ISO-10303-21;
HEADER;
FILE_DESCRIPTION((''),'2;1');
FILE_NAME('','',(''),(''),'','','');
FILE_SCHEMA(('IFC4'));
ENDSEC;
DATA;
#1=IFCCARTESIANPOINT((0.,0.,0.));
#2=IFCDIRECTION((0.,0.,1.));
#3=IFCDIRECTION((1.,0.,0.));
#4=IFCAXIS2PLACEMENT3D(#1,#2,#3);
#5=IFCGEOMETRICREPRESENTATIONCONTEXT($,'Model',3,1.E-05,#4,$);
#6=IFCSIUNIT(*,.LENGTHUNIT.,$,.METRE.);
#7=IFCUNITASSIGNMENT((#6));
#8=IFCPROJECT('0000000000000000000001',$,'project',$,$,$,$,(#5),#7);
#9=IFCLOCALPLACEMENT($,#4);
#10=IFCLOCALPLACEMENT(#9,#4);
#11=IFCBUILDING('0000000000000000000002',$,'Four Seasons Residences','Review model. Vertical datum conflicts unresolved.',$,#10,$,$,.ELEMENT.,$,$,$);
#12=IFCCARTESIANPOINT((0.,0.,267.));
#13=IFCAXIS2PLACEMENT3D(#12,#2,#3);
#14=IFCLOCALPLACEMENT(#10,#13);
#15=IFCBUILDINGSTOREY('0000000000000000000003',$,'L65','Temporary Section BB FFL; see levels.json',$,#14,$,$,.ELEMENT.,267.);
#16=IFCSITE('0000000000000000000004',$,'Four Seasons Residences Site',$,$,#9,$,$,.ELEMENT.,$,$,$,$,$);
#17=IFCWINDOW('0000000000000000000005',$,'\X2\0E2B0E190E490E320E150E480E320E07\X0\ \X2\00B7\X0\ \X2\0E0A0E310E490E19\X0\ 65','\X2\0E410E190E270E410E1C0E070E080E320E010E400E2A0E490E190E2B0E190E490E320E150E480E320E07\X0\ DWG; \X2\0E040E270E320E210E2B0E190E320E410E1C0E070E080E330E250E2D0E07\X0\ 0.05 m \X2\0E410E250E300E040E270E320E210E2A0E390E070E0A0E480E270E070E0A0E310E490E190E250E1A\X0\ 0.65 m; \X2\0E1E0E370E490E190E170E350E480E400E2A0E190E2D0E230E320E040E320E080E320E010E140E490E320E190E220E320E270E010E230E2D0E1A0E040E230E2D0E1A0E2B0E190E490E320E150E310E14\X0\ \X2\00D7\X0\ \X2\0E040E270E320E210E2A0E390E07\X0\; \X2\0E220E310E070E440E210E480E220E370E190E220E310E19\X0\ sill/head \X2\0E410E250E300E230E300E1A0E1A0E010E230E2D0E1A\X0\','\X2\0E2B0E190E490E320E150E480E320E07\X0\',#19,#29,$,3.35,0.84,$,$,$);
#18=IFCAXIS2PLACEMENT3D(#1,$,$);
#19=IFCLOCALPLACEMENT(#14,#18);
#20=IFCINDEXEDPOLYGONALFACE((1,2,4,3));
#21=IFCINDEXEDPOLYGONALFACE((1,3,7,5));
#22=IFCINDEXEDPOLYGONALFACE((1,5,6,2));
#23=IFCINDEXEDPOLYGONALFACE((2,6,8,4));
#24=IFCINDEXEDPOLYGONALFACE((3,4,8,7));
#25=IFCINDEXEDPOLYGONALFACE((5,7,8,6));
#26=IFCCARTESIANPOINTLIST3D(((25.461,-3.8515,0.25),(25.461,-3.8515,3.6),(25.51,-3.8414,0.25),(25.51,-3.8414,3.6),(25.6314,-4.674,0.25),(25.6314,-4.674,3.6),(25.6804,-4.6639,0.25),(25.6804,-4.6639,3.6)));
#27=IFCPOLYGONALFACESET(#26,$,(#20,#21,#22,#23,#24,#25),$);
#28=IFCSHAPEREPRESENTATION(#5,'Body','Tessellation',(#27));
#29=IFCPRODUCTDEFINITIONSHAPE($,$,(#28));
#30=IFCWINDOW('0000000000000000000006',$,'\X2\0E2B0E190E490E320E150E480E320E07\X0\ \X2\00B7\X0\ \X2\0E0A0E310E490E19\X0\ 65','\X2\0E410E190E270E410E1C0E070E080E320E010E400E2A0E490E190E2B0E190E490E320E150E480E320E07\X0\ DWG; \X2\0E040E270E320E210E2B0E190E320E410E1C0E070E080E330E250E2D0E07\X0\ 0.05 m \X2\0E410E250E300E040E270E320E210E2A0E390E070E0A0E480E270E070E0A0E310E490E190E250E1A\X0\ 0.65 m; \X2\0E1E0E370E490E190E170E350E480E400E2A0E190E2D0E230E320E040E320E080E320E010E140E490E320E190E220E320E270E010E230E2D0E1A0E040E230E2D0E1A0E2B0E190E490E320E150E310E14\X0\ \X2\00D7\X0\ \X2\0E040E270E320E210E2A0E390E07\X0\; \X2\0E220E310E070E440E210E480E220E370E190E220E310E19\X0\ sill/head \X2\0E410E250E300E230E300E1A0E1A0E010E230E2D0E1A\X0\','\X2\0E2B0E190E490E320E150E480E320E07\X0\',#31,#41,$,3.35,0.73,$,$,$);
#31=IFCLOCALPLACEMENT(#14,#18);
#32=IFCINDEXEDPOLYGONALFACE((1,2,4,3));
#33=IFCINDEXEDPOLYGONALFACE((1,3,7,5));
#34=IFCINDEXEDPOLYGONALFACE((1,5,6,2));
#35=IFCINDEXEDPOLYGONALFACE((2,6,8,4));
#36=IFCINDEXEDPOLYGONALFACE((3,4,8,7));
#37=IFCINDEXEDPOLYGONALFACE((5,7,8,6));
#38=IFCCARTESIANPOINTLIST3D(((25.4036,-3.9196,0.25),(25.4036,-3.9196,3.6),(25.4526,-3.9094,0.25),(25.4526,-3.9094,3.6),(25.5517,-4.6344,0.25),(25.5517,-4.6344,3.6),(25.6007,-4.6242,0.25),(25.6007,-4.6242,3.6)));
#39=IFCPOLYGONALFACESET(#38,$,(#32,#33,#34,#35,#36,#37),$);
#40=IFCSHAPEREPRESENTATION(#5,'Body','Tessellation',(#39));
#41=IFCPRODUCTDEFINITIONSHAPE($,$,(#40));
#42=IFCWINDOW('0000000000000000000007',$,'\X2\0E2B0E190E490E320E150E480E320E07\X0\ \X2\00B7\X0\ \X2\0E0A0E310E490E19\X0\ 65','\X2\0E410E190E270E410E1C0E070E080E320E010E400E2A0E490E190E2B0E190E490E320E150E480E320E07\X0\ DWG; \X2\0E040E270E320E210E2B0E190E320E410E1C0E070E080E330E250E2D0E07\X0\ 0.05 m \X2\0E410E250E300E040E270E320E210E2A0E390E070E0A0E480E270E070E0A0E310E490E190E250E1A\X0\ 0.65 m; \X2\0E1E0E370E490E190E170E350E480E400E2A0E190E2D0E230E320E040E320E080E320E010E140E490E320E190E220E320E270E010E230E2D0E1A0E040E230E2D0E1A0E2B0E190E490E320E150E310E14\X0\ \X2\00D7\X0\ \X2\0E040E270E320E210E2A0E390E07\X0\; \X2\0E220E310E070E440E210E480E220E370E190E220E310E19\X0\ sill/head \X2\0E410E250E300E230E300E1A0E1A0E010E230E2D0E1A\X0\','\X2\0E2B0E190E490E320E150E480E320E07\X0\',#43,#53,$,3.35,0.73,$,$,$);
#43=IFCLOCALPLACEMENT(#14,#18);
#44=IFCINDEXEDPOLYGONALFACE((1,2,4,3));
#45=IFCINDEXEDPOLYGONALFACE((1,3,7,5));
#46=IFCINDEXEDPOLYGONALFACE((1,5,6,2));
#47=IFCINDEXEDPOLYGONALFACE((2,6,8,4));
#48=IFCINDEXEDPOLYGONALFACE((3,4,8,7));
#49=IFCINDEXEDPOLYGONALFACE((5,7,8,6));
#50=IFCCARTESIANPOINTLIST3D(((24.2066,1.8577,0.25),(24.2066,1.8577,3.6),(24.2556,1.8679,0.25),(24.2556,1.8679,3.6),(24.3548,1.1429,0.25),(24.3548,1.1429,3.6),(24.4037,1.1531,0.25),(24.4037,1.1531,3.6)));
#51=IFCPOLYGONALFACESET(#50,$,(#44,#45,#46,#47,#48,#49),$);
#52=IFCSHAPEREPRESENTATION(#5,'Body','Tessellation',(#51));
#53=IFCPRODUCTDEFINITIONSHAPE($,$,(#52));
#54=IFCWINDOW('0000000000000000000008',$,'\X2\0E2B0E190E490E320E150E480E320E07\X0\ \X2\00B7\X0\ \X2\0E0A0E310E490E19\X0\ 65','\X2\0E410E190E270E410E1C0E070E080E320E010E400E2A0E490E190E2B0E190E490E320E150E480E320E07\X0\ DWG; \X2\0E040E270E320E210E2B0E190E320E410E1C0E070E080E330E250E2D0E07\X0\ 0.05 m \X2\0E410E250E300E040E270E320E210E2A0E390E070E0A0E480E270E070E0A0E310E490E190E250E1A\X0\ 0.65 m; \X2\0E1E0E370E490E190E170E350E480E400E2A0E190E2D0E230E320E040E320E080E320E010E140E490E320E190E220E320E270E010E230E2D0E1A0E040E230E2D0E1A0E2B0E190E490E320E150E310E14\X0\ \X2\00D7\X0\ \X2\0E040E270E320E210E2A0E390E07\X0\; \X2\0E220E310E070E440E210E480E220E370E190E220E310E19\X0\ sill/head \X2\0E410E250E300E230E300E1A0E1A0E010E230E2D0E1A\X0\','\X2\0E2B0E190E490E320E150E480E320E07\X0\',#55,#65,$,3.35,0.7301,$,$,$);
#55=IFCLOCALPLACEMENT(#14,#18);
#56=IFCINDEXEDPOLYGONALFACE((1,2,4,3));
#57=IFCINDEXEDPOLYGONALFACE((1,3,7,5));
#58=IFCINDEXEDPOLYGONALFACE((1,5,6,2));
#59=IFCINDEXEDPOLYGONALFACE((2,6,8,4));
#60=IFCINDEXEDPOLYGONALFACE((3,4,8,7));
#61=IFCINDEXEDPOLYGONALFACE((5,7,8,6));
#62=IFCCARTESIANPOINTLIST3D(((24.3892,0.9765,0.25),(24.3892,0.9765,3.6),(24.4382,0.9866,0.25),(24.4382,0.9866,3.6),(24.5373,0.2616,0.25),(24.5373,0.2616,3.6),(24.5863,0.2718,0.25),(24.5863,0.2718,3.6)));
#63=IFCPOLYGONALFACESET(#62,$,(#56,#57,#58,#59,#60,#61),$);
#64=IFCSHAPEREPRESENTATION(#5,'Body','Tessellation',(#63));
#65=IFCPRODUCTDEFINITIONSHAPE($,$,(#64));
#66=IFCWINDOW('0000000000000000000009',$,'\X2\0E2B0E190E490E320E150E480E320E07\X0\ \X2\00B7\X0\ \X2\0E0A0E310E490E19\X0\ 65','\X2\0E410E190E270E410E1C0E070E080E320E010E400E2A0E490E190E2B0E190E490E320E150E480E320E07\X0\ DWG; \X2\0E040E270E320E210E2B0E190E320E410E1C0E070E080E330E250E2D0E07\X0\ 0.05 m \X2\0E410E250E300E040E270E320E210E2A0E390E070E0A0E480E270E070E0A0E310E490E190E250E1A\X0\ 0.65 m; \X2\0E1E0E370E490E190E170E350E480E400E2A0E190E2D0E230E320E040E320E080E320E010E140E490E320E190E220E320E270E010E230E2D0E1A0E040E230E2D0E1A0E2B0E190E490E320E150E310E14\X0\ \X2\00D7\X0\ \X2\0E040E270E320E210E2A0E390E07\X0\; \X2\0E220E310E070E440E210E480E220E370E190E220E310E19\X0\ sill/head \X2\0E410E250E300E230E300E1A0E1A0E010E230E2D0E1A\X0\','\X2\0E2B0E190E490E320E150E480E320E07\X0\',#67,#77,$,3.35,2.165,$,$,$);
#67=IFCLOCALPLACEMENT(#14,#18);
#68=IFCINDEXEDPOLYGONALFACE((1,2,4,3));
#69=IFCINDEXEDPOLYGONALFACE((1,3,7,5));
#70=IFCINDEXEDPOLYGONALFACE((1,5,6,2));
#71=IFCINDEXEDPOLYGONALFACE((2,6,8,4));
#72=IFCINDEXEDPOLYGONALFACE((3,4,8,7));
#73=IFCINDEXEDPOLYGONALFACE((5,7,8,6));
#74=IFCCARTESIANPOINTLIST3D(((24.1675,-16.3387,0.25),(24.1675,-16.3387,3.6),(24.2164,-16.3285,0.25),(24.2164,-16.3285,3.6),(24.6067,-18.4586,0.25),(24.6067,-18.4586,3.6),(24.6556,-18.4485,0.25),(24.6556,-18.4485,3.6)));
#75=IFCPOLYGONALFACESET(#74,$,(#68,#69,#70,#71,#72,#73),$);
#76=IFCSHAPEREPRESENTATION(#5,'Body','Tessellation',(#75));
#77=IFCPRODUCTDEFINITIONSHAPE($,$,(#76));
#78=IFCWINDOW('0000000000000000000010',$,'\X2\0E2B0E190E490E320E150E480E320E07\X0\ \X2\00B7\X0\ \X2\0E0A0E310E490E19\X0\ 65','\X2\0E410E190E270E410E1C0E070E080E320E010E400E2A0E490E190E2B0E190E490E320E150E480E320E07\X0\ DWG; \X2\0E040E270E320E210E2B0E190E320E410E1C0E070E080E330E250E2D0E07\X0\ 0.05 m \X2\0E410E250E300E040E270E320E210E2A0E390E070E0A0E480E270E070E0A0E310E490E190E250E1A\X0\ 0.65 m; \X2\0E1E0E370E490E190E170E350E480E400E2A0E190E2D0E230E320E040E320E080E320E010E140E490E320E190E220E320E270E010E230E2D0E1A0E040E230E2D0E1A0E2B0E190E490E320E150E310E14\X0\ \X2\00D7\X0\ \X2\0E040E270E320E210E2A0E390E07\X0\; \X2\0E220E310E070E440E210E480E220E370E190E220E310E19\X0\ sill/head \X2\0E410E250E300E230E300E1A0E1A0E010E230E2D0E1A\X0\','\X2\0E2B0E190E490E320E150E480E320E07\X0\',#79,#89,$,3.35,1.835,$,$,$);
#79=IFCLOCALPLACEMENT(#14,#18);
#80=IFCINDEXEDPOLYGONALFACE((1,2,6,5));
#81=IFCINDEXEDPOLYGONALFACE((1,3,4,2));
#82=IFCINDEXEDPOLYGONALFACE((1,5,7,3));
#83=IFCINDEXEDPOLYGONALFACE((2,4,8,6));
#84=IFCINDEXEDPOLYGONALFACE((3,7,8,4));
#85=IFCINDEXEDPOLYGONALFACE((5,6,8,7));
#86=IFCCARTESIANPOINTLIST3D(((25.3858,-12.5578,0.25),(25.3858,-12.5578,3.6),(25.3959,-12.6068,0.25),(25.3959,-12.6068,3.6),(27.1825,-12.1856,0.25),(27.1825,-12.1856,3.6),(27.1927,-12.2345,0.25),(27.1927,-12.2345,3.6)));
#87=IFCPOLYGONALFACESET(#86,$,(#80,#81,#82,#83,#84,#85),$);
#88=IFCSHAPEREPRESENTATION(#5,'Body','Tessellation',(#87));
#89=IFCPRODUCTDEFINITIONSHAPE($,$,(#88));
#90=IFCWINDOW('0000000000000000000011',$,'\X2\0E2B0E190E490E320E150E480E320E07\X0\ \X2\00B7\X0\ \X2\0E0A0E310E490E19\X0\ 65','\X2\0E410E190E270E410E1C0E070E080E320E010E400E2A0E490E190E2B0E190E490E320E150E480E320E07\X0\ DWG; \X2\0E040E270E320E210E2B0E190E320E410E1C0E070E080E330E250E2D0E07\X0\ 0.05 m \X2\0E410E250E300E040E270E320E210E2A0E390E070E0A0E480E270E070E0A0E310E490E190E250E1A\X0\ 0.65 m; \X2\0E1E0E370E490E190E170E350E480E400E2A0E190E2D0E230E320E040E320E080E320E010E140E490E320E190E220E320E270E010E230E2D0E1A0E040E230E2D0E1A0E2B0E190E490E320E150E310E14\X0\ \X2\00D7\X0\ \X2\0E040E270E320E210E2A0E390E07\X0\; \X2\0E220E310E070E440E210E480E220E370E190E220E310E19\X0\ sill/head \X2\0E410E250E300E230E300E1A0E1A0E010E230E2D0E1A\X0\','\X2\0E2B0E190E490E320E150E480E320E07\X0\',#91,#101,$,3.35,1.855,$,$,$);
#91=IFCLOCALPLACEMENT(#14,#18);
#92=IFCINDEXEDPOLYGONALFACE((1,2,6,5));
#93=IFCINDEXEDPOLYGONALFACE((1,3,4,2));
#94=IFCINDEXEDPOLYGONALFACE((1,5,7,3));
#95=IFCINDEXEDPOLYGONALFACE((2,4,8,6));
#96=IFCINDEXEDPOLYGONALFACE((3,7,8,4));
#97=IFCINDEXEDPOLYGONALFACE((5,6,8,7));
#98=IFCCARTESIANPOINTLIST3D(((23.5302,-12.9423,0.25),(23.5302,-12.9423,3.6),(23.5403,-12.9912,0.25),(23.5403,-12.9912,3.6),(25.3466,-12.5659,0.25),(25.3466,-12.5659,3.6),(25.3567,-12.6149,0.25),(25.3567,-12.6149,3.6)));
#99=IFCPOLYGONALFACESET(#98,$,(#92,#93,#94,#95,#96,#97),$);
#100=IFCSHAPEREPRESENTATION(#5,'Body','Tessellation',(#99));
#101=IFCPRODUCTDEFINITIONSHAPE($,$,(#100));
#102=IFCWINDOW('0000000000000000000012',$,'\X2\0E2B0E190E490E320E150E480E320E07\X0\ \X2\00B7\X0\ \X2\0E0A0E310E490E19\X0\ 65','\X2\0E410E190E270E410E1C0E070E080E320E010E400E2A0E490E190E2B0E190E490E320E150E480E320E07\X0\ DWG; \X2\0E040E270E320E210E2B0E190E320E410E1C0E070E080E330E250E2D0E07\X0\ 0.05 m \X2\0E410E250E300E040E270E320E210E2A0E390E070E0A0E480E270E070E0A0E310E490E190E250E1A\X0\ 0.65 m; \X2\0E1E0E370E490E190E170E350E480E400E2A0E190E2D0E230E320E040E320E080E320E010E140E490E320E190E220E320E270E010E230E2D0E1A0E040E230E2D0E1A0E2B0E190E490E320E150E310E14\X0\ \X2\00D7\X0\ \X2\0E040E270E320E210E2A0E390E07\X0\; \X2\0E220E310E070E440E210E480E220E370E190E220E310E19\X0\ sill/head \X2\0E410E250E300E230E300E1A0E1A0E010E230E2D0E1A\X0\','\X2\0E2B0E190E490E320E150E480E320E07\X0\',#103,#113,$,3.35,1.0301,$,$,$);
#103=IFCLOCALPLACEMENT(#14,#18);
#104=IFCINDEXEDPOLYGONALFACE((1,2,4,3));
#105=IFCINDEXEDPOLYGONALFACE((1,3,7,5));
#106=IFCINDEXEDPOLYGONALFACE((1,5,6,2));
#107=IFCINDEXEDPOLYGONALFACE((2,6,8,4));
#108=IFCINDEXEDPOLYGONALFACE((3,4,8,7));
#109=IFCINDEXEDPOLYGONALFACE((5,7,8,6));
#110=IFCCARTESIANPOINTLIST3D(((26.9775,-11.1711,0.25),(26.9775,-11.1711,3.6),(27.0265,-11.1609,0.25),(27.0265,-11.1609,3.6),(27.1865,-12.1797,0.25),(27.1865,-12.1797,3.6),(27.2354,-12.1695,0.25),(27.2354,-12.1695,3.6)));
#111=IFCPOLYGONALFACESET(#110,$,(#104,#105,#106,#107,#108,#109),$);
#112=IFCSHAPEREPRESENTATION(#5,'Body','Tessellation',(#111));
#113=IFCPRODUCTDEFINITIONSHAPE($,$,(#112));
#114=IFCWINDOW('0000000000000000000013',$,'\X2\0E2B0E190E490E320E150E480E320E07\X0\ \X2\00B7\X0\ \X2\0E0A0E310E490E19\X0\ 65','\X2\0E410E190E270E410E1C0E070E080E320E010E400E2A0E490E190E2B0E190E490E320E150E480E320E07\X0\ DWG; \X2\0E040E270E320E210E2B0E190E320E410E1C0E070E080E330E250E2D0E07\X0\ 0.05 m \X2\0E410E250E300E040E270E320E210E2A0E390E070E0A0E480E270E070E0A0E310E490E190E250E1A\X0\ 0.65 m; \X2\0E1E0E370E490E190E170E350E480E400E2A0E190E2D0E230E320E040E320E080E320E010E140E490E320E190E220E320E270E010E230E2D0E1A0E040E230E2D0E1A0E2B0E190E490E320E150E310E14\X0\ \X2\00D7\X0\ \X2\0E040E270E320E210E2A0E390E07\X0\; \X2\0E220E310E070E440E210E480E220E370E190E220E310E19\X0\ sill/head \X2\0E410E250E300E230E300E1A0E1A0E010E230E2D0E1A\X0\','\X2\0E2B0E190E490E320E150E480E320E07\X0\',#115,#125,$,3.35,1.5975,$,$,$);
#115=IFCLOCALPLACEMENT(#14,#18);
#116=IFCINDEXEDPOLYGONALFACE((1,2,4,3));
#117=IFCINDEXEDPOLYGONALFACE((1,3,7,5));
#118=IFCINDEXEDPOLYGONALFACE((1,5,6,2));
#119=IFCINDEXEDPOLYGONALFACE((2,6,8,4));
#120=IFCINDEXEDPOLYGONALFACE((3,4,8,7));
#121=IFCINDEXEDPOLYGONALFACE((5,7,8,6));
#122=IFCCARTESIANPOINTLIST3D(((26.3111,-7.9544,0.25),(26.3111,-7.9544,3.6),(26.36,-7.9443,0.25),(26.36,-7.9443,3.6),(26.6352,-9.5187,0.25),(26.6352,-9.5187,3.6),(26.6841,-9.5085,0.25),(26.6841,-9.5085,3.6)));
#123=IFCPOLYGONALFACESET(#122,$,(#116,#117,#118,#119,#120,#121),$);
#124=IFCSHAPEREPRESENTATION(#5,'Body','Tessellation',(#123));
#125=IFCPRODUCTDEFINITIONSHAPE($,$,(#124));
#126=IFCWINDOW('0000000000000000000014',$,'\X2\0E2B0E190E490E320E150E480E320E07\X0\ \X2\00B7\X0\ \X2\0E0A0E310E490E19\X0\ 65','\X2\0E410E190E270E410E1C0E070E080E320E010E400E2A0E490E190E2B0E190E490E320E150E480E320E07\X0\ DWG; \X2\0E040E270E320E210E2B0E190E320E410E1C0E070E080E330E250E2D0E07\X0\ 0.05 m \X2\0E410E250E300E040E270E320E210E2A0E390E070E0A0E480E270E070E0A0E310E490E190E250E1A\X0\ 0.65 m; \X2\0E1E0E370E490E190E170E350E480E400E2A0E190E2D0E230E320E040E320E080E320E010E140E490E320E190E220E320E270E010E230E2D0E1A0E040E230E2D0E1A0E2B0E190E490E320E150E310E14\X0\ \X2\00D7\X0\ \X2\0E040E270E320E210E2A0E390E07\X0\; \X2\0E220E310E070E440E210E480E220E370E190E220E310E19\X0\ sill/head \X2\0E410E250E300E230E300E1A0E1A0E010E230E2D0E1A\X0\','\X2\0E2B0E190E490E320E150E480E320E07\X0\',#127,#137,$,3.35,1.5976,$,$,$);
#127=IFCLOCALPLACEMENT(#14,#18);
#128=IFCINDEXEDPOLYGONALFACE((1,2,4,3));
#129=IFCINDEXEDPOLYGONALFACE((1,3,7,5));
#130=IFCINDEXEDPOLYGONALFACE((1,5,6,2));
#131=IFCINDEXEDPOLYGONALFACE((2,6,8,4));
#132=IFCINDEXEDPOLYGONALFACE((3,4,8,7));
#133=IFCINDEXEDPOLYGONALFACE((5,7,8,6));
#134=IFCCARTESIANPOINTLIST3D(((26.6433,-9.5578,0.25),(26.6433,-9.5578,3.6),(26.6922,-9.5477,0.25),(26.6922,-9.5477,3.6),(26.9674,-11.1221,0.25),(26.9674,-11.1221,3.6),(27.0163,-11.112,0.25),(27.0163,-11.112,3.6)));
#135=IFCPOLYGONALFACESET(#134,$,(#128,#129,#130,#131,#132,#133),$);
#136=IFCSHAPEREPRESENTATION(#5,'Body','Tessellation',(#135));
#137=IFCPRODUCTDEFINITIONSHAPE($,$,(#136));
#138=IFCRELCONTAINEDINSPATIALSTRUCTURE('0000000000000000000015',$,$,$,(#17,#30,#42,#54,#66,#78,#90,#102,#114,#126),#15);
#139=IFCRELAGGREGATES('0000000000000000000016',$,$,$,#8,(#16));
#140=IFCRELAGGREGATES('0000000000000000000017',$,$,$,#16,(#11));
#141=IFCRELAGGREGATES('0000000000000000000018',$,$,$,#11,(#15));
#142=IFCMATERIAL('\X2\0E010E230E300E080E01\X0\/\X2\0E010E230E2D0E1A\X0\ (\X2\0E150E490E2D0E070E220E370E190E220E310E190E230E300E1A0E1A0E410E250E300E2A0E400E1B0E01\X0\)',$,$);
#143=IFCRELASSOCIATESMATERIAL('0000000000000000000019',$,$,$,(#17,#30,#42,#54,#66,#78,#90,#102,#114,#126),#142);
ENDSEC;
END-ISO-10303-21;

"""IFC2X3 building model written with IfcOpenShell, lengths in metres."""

from ifc_helpers import new_model, si_unit, frame, origin_with_axes, place, context, project, spatial, polyline, outline, extrude, material, element, save


model = new_model("IFC2X3")

# Units and contexts
model_context = context("Model", 3, precision=1e-05, world=origin_with_axes())
ifc_project = project(units=[si_unit("LENGTHUNIT", "METRE")], contexts=[model_context])

# Site, building, storey
site_placement = place(None, origin_with_axes())
site = spatial("IfcSite", under=ifc_project, at=site_placement, Name="Four Seasons Residences Site", CompositionType="ELEMENT")
building_placement = place(site_placement, origin_with_axes())
building = spatial("IfcBuilding", under=site, at=building_placement, Name="Four Seasons Residences", Description="Review model. Vertical datum conflicts unresolved.", CompositionType="ELEMENT")
storey_placement = place(building_placement, frame((0.0, 0.0, 267.0), z_axis=(0.0, 0.0, 1.0), x_axis=(1.0, 0.0, 0.0)))
storey = spatial("IfcBuildingStorey", under=building, at=storey_placement, Name="L65", Description="Temporary Section BB FFL; see levels.json", CompositionType="ELEMENT", Elevation=267.0)

# Windows
ifc_material = material(Name="กระจก/กรอบ (ต้องยืนยันระบบและสเปก)")
window_1_placement = place(storey_placement, origin_with_axes())
element("IfcWindow", 1, at=window_1_placement, inside=storey, material=ifc_material, Name="หน้าต่าง · ชั้น 65", Description="แนวแผงจากเส้นหน้าต่าง DWG; ความหนาแผงจำลอง 0.05 m และความสูงช่วงชั้นลบ 0.65 m; พื้นที่เสนอราคาจากด้านยาวกรอบครอบหน้าตัด × ความสูง; ยังไม่ยืนยัน sill/head และระบบกรอบ", ObjectType="หน้าต่าง", OverallHeight=3.35, OverallWidth=0.84, context=model_context, shape_type="SweptSolid", body=[
    extrude(outline(polyline([(25.461, -3.8515), (25.51, -3.8414), (25.6804, -4.6639), (25.6314, -4.674), (25.461, -3.8515)])), frame((0.0, 0.0, 0.25), z_axis=(0.0, 0.0, 1.0), x_axis=(1.0, 0.0, 0.0)), (0.0, 0.0, 1.0), 3.35),
])
window_2_placement = place(storey_placement, origin_with_axes())
element("IfcWindow", 2, at=window_2_placement, inside=storey, material=ifc_material, Name="หน้าต่าง · ชั้น 65", Description="แนวแผงจากเส้นหน้าต่าง DWG; ความหนาแผงจำลอง 0.05 m และความสูงช่วงชั้นลบ 0.65 m; พื้นที่เสนอราคาจากด้านยาวกรอบครอบหน้าตัด × ความสูง; ยังไม่ยืนยัน sill/head และระบบกรอบ", ObjectType="หน้าต่าง", OverallHeight=3.35, OverallWidth=0.73, context=model_context, shape_type="SweptSolid", body=[
    extrude(outline(polyline([(25.6007, -4.6242), (25.5517, -4.6344), (25.4036, -3.9196), (25.4526, -3.9094), (25.6007, -4.6242)])), frame((0.0, 0.0, 0.25), z_axis=(0.0, 0.0, 1.0), x_axis=(1.0, 0.0, 0.0)), (0.0, 0.0, 1.0), 3.35),
])
window_3_placement = place(storey_placement, origin_with_axes())
element("IfcWindow", 3, at=window_3_placement, inside=storey, material=ifc_material, Name="หน้าต่าง · ชั้น 65", Description="แนวแผงจากเส้นหน้าต่าง DWG; ความหนาแผงจำลอง 0.05 m และความสูงช่วงชั้นลบ 0.65 m; พื้นที่เสนอราคาจากด้านยาวกรอบครอบหน้าตัด × ความสูง; ยังไม่ยืนยัน sill/head และระบบกรอบ", ObjectType="หน้าต่าง", OverallHeight=3.35, OverallWidth=0.73, context=model_context, shape_type="SweptSolid", body=[
    extrude(outline(polyline([(24.4037, 1.1531), (24.3548, 1.1429), (24.2066, 1.8577), (24.2556, 1.8679), (24.4037, 1.1531)])), frame((0.0, 0.0, 0.25), z_axis=(0.0, 0.0, 1.0), x_axis=(1.0, 0.0, 0.0)), (0.0, 0.0, 1.0), 3.35),
])
window_4_placement = place(storey_placement, origin_with_axes())
element("IfcWindow", 4, at=window_4_placement, inside=storey, material=ifc_material, Name="หน้าต่าง · ชั้น 65", Description="แนวแผงจากเส้นหน้าต่าง DWG; ความหนาแผงจำลอง 0.05 m และความสูงช่วงชั้นลบ 0.65 m; พื้นที่เสนอราคาจากด้านยาวกรอบครอบหน้าตัด × ความสูง; ยังไม่ยืนยัน sill/head และระบบกรอบ", ObjectType="หน้าต่าง", OverallHeight=3.35, OverallWidth=0.7301, context=model_context, shape_type="SweptSolid", body=[
    extrude(outline(polyline([(24.5863, 0.2718), (24.5373, 0.2616), (24.3892, 0.9765), (24.4382, 0.9866), (24.5863, 0.2718)])), frame((0.0, 0.0, 0.25), z_axis=(0.0, 0.0, 1.0), x_axis=(1.0, 0.0, 0.0)), (0.0, 0.0, 1.0), 3.35),
])
window_5_placement = place(storey_placement, origin_with_axes())
element("IfcWindow", 5, at=window_5_placement, inside=storey, material=ifc_material, Name="หน้าต่าง · ชั้น 65", Description="แนวแผงจากเส้นหน้าต่าง DWG; ความหนาแผงจำลอง 0.05 m และความสูงช่วงชั้นลบ 0.65 m; พื้นที่เสนอราคาจากด้านยาวกรอบครอบหน้าตัด × ความสูง; ยังไม่ยืนยัน sill/head และระบบกรอบ", ObjectType="หน้าต่าง", OverallHeight=3.35, OverallWidth=2.165, context=model_context, shape_type="SweptSolid", body=[
    extrude(outline(polyline([(24.6556, -18.4485), (24.6067, -18.4586), (24.1675, -16.3387), (24.2164, -16.3285), (24.6556, -18.4485)])), frame((0.0, 0.0, 0.25), z_axis=(0.0, 0.0, 1.0), x_axis=(1.0, 0.0, 0.0)), (0.0, 0.0, 1.0), 3.35),
])
window_6_placement = place(storey_placement, origin_with_axes())
element("IfcWindow", 6, at=window_6_placement, inside=storey, material=ifc_material, Name="หน้าต่าง · ชั้น 65", Description="แนวแผงจากเส้นหน้าต่าง DWG; ความหนาแผงจำลอง 0.05 m และความสูงช่วงชั้นลบ 0.65 m; พื้นที่เสนอราคาจากด้านยาวกรอบครอบหน้าตัด × ความสูง; ยังไม่ยืนยัน sill/head และระบบกรอบ", ObjectType="หน้าต่าง", OverallHeight=3.35, OverallWidth=1.835, context=model_context, shape_type="SweptSolid", body=[
    extrude(outline(polyline([(25.3959, -12.6068), (25.3858, -12.5578), (27.1825, -12.1856), (27.1927, -12.2345), (25.3959, -12.6068)])), frame((0.0, 0.0, 0.25), z_axis=(0.0, 0.0, 1.0), x_axis=(1.0, 0.0, 0.0)), (0.0, 0.0, 1.0), 3.35),
])
window_7_placement = place(storey_placement, origin_with_axes())
element("IfcWindow", 7, at=window_7_placement, inside=storey, material=ifc_material, Name="หน้าต่าง · ชั้น 65", Description="แนวแผงจากเส้นหน้าต่าง DWG; ความหนาแผงจำลอง 0.05 m และความสูงช่วงชั้นลบ 0.65 m; พื้นที่เสนอราคาจากด้านยาวกรอบครอบหน้าตัด × ความสูง; ยังไม่ยืนยัน sill/head และระบบกรอบ", ObjectType="หน้าต่าง", OverallHeight=3.35, OverallWidth=1.855, context=model_context, shape_type="SweptSolid", body=[
    extrude(outline(polyline([(23.5403, -12.9912), (23.5302, -12.9423), (25.3466, -12.5659), (25.3567, -12.6149), (23.5403, -12.9912)])), frame((0.0, 0.0, 0.25), z_axis=(0.0, 0.0, 1.0), x_axis=(1.0, 0.0, 0.0)), (0.0, 0.0, 1.0), 3.35),
])
window_8_placement = place(storey_placement, origin_with_axes())
element("IfcWindow", 8, at=window_8_placement, inside=storey, material=ifc_material, Name="หน้าต่าง · ชั้น 65", Description="แนวแผงจากเส้นหน้าต่าง DWG; ความหนาแผงจำลอง 0.05 m และความสูงช่วงชั้นลบ 0.65 m; พื้นที่เสนอราคาจากด้านยาวกรอบครอบหน้าตัด × ความสูง; ยังไม่ยืนยัน sill/head และระบบกรอบ", ObjectType="หน้าต่าง", OverallHeight=3.35, OverallWidth=1.0301, context=model_context, shape_type="SweptSolid", body=[
    extrude(outline(polyline([(27.2354, -12.1695), (27.1865, -12.1797), (26.9775, -11.1711), (27.0265, -11.1609), (27.2354, -12.1695)])), frame((0.0, 0.0, 0.25), z_axis=(0.0, 0.0, 1.0), x_axis=(1.0, 0.0, 0.0)), (0.0, 0.0, 1.0), 3.35),
])
window_9_placement = place(storey_placement, origin_with_axes())
element("IfcWindow", 9, at=window_9_placement, inside=storey, material=ifc_material, Name="หน้าต่าง · ชั้น 65", Description="แนวแผงจากเส้นหน้าต่าง DWG; ความหนาแผงจำลอง 0.05 m และความสูงช่วงชั้นลบ 0.65 m; พื้นที่เสนอราคาจากด้านยาวกรอบครอบหน้าตัด × ความสูง; ยังไม่ยืนยัน sill/head และระบบกรอบ", ObjectType="หน้าต่าง", OverallHeight=3.35, OverallWidth=1.5975, context=model_context, shape_type="SweptSolid", body=[
    extrude(outline(polyline([(26.3111, -7.9544), (26.36, -7.9443), (26.6841, -9.5085), (26.6352, -9.5187), (26.3111, -7.9544)])), frame((0.0, 0.0, 0.25), z_axis=(0.0, 0.0, 1.0), x_axis=(1.0, 0.0, 0.0)), (0.0, 0.0, 1.0), 3.35),
])
window_10_placement = place(storey_placement, origin_with_axes())
element("IfcWindow", 10, at=window_10_placement, inside=storey, material=ifc_material, Name="หน้าต่าง · ชั้น 65", Description="แนวแผงจากเส้นหน้าต่าง DWG; ความหนาแผงจำลอง 0.05 m และความสูงช่วงชั้นลบ 0.65 m; พื้นที่เสนอราคาจากด้านยาวกรอบครอบหน้าตัด × ความสูง; ยังไม่ยืนยัน sill/head และระบบกรอบ", ObjectType="หน้าต่าง", OverallHeight=3.35, OverallWidth=1.5976, context=model_context, shape_type="SweptSolid", body=[
    extrude(outline(polyline([(27.0163, -11.112), (26.9674, -11.1221), (26.6433, -9.5578), (26.6922, -9.5477), (27.0163, -11.112)])), frame((0.0, 0.0, 0.25), z_axis=(0.0, 0.0, 1.0), x_axis=(1.0, 0.0, 0.0)), (0.0, 0.0, 1.0), 3.35),
])

save(model, "model.ifc")
